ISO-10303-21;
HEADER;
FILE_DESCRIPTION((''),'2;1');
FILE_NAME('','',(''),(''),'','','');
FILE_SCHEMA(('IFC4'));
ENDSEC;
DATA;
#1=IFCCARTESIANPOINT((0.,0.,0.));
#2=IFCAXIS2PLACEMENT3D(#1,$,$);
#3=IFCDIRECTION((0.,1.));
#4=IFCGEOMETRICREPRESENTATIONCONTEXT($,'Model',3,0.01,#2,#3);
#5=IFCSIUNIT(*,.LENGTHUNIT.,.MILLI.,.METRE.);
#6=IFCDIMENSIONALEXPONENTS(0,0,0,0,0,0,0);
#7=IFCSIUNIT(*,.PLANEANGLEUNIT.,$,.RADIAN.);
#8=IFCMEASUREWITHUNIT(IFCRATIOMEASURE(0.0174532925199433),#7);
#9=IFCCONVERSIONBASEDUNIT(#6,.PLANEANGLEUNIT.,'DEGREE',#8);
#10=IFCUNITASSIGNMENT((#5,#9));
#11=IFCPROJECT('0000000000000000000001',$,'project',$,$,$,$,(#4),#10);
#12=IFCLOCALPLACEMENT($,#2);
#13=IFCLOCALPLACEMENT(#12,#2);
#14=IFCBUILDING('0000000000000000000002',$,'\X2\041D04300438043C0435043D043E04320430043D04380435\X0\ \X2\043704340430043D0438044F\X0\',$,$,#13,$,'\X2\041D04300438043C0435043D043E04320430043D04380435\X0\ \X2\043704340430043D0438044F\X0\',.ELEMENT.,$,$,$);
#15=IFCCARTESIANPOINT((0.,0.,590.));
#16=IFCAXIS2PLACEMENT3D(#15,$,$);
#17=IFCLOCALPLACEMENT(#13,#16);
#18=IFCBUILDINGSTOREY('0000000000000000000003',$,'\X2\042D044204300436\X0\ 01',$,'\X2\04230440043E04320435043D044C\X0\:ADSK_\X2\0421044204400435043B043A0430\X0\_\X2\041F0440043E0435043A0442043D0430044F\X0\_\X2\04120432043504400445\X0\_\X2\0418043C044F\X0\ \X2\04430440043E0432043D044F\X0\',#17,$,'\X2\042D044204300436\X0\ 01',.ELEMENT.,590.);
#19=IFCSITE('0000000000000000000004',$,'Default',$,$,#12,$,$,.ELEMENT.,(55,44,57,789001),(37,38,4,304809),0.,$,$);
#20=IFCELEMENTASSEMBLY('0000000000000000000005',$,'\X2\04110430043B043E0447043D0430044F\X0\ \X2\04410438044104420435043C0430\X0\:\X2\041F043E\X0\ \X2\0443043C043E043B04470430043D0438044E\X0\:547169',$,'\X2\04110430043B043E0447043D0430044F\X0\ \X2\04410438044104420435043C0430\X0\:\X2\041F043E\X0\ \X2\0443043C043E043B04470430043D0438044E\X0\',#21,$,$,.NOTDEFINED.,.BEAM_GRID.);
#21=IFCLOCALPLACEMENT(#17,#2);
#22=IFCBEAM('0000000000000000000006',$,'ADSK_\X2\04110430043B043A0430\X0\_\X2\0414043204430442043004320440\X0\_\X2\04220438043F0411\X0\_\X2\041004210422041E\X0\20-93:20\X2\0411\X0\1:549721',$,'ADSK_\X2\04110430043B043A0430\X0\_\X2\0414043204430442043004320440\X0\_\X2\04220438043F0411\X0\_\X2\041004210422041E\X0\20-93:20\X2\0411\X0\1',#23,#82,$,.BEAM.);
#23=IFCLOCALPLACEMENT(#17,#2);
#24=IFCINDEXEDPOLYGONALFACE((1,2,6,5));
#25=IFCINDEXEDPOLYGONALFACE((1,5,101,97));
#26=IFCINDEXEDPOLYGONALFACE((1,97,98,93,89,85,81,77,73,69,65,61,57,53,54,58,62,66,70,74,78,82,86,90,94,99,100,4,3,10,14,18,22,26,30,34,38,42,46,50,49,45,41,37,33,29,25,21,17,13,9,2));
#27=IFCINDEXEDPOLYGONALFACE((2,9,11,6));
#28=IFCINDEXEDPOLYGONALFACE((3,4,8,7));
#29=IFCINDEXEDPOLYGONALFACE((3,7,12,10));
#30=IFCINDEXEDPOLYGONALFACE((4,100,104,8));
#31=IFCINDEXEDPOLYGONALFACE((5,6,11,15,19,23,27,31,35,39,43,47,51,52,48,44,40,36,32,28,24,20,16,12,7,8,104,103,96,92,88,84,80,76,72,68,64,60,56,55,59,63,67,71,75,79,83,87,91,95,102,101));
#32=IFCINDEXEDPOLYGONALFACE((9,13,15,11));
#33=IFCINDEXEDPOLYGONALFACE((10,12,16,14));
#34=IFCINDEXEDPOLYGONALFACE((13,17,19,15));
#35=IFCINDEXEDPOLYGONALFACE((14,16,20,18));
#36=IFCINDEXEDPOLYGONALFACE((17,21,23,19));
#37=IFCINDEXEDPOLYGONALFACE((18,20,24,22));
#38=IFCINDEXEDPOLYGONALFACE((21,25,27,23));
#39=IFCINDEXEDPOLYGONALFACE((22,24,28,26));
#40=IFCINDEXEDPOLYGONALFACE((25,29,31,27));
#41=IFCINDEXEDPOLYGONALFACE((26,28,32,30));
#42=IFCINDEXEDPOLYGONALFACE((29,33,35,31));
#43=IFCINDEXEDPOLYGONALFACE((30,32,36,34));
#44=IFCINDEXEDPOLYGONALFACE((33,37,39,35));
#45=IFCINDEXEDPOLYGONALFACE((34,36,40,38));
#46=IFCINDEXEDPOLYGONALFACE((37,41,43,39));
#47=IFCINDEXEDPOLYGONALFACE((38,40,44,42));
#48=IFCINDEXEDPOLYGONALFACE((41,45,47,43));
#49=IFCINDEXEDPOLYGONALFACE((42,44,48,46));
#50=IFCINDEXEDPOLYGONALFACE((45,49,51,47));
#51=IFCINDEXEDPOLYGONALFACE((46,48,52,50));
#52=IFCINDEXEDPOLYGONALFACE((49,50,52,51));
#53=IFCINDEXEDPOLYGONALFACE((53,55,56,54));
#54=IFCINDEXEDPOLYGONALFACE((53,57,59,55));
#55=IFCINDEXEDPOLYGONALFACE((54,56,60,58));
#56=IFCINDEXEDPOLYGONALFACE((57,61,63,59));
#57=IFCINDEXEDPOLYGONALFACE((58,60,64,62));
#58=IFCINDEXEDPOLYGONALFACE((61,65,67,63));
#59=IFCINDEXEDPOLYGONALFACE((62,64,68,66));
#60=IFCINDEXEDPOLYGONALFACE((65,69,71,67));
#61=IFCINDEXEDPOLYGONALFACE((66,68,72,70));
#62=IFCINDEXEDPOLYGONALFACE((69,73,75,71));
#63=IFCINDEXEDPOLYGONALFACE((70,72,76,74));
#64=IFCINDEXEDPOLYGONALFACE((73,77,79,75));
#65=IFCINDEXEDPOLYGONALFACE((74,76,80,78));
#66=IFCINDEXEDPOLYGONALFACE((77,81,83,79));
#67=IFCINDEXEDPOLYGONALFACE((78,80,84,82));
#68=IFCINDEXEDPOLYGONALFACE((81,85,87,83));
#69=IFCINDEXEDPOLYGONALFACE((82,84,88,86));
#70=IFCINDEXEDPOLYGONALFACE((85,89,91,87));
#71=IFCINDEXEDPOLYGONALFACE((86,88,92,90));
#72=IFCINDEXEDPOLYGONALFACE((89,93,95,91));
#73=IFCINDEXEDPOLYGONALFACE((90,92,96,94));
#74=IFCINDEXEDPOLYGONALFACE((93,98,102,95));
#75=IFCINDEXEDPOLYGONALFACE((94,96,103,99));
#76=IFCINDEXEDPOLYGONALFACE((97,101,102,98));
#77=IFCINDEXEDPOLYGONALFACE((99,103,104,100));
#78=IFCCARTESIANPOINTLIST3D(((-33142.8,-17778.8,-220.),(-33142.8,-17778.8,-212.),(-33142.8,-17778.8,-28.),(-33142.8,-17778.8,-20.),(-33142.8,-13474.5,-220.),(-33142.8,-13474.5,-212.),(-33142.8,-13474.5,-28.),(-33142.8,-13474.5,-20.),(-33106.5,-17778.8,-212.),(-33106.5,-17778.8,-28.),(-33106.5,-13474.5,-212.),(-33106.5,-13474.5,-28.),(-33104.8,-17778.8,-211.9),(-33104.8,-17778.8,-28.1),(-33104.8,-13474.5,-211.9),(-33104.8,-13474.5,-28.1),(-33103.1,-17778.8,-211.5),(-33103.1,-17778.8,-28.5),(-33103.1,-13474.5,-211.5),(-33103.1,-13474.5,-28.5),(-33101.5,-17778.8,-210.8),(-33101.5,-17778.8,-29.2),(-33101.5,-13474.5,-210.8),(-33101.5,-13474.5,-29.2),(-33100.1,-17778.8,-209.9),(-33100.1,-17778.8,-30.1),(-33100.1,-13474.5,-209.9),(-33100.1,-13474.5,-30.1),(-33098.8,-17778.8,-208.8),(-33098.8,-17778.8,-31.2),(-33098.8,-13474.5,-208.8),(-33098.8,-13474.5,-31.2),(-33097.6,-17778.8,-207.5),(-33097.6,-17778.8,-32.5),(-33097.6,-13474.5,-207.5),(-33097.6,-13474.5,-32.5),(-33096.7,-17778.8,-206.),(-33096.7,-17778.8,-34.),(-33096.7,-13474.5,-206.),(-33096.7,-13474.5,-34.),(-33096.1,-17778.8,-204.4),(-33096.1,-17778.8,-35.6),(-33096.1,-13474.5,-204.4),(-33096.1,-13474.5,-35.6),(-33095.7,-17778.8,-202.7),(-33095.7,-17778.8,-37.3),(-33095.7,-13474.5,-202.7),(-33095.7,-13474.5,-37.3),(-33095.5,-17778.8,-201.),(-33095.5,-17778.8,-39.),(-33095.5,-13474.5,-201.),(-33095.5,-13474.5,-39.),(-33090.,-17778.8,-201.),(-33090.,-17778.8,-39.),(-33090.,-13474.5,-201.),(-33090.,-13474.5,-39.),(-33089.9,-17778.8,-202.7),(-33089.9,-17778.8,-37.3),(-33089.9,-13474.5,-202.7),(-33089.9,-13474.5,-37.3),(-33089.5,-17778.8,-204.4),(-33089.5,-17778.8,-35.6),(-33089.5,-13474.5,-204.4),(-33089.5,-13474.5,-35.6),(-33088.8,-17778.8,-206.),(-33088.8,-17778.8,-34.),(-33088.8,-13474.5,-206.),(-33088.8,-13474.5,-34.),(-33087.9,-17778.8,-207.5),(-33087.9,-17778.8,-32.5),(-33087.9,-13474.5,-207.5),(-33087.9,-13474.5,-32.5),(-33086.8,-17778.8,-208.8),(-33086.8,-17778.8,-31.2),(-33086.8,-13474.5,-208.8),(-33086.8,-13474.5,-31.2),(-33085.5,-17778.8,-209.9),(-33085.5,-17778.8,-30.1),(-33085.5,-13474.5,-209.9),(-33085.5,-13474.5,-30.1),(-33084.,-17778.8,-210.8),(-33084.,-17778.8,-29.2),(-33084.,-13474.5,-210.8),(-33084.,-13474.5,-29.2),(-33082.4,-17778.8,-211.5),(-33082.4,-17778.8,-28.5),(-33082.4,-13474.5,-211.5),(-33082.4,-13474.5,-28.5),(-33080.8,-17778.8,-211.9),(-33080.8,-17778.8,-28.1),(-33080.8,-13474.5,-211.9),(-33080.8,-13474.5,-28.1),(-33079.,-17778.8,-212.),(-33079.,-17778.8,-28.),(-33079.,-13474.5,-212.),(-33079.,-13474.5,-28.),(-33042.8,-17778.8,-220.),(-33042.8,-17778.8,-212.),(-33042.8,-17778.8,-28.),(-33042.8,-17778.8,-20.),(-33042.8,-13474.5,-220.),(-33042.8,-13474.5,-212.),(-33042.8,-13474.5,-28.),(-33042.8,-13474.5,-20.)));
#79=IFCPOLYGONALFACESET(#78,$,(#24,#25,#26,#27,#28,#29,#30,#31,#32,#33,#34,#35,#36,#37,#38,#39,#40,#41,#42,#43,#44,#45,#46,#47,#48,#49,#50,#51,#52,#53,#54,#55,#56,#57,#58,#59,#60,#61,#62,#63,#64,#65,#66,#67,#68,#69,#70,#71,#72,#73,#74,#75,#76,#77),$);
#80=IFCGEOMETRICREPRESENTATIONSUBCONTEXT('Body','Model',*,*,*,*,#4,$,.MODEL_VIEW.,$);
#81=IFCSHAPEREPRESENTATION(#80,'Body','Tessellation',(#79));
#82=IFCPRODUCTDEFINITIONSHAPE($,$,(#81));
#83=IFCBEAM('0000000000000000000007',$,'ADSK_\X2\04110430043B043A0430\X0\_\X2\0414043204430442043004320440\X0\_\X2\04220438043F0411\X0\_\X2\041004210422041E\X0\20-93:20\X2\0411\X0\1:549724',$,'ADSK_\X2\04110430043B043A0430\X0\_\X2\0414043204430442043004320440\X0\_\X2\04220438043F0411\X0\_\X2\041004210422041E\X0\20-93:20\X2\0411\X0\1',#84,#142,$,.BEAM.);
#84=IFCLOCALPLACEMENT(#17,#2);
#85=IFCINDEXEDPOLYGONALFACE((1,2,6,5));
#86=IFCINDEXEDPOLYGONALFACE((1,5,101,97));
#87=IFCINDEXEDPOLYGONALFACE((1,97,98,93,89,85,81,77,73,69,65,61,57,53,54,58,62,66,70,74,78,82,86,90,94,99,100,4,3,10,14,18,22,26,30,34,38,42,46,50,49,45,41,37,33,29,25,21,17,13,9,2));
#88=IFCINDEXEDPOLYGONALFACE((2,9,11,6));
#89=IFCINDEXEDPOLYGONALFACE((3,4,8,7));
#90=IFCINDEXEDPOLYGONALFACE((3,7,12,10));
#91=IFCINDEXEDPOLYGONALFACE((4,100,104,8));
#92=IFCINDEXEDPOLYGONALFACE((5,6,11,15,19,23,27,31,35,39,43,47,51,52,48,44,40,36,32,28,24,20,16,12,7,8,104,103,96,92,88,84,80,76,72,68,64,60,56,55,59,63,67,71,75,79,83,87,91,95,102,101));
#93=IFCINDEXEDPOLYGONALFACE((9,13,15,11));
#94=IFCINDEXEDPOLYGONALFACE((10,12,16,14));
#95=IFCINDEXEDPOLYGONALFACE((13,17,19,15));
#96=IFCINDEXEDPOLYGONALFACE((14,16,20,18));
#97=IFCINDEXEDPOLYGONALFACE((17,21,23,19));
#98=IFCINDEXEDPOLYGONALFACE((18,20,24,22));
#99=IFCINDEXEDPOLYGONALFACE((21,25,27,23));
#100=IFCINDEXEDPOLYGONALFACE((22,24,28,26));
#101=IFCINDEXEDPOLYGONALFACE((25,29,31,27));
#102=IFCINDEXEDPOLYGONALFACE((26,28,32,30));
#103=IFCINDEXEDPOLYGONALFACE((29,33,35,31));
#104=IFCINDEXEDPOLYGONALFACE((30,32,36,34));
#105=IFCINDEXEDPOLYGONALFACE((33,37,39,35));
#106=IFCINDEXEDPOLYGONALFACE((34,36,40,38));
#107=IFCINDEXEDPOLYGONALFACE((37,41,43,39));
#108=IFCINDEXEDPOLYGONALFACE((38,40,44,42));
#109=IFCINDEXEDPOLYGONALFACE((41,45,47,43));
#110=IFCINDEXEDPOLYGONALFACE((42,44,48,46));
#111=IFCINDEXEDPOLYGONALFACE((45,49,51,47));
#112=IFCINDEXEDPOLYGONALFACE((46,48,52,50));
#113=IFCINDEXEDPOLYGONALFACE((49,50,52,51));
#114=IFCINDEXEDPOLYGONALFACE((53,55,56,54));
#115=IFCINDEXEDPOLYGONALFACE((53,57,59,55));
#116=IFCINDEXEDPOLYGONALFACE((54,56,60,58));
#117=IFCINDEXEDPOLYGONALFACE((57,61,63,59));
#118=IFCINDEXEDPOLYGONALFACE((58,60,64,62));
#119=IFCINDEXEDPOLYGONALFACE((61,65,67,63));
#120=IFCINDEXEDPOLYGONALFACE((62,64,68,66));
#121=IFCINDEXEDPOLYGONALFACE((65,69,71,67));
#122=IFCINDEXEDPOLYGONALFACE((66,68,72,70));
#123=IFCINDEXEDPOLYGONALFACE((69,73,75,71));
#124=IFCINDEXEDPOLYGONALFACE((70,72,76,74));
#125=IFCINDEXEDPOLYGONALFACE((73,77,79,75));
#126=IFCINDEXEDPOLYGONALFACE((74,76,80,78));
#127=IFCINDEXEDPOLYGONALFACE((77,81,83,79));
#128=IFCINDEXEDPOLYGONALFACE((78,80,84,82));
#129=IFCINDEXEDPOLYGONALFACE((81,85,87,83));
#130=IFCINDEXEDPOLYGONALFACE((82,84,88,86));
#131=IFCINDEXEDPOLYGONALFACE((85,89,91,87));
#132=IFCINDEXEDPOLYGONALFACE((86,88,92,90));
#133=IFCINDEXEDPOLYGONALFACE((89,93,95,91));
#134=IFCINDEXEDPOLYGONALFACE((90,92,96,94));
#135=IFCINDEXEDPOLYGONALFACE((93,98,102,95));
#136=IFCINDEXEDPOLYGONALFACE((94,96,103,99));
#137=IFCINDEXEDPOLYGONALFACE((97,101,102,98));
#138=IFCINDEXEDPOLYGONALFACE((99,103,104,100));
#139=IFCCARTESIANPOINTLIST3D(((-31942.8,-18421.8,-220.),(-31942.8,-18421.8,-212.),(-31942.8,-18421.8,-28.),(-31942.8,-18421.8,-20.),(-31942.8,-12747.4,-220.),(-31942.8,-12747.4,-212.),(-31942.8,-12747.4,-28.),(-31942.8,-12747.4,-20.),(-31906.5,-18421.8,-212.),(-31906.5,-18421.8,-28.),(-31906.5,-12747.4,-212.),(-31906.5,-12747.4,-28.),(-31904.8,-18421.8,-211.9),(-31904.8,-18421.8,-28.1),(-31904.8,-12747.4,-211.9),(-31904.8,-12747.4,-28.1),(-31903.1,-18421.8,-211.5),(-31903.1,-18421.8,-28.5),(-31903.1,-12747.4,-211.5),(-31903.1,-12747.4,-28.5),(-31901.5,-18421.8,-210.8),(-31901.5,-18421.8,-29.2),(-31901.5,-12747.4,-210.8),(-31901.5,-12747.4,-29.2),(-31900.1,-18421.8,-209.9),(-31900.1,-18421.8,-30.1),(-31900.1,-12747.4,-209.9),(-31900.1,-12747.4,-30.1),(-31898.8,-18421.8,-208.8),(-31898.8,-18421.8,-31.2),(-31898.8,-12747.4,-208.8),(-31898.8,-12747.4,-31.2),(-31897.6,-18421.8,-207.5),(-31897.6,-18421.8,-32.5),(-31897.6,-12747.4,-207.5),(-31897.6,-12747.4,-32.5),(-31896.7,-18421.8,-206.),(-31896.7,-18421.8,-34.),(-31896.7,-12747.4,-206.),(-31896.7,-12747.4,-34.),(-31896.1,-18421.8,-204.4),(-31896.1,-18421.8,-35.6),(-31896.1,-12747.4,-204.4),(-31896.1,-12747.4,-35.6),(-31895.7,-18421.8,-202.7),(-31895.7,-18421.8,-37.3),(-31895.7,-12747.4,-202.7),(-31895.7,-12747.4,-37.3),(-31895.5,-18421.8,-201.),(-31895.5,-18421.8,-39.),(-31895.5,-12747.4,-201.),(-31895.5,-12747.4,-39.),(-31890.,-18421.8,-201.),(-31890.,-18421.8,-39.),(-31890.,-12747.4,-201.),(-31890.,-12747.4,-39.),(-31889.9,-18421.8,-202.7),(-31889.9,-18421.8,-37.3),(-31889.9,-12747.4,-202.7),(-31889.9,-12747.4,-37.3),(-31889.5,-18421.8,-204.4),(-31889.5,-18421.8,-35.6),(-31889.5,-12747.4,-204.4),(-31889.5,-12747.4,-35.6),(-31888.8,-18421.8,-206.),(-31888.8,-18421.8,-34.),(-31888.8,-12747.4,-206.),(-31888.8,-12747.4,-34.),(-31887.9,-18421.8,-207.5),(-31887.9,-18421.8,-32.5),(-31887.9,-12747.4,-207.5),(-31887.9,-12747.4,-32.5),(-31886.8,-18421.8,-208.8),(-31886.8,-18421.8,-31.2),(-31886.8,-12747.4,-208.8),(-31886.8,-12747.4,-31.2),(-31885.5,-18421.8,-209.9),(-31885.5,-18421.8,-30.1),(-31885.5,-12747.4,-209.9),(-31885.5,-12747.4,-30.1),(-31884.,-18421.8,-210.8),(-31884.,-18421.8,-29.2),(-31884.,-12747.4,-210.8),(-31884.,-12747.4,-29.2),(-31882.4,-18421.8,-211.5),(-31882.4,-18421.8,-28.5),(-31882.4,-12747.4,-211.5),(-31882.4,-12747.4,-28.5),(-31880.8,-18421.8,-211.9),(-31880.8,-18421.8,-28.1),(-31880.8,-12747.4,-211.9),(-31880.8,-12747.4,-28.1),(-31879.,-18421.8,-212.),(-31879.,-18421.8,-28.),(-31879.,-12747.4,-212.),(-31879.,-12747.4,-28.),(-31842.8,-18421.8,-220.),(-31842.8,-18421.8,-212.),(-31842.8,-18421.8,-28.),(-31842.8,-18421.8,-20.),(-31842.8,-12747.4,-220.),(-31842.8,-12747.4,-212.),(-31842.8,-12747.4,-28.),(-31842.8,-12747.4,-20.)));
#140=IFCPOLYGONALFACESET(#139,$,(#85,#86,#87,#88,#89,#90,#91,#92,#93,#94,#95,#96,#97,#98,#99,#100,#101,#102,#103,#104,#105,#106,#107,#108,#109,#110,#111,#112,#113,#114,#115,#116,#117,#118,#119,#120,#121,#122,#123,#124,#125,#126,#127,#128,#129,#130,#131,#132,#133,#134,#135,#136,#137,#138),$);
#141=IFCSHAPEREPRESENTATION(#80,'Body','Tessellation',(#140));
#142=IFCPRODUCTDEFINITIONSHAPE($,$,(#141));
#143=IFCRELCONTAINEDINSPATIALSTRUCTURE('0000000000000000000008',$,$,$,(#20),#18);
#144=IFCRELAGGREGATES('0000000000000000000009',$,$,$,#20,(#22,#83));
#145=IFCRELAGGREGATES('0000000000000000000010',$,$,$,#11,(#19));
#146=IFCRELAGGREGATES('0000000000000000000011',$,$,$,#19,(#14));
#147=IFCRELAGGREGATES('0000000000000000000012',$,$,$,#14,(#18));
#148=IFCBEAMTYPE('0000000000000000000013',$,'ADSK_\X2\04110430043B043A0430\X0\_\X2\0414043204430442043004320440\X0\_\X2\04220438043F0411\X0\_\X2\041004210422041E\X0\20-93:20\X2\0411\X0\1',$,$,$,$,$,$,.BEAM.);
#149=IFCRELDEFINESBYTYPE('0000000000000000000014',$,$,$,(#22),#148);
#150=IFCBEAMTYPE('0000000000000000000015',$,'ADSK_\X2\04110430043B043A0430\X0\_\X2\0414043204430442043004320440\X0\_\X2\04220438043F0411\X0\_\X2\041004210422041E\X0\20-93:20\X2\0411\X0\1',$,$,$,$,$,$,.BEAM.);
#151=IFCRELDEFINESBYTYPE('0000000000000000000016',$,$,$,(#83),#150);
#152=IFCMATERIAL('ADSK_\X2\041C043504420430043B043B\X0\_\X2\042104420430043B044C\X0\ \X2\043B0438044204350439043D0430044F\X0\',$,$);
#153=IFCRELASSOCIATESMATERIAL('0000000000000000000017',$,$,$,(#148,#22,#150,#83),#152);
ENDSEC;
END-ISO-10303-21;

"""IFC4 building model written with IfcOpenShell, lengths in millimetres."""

from ifc_helpers import new_model, entity, si_unit, converted_unit, direction, frame, origin, place, context, subcontext, project, spatial, indexed_curve, outline, extrude, source, transform, mapped, material, type_object, type_shapes, element, aggregate, save


model = new_model("IFC4")

# Units and contexts
model_context = context("Model", 3, precision=0.01, world=origin(), true_north=direction((0.0, 1.0)))
body_context = subcontext(model_context, "Body", "Model", "MODEL_VIEW")
ifc_project = project(units=[si_unit("LENGTHUNIT", "METRE", prefix="MILLI"), converted_unit("PLANEANGLEUNIT", "DEGREE", entity("IfcRatioMeasure", 0.0174532925199433), si_unit("PLANEANGLEUNIT", "RADIAN"), dimensions=[0, 0, 0, 0, 0, 0, 0])], contexts=[model_context])

# Site, building, storey
site_placement = place(None, origin())
site = spatial("IfcSite", under=ifc_project, at=site_placement, Name="Default", CompositionType="ELEMENT", RefLatitude=(55, 44, 57, 789001), RefLongitude=(37, 38, 4, 304809), RefElevation=0.0)
building_placement = place(site_placement, origin())
building = spatial("IfcBuilding", under=site, at=building_placement, Name="Наименование здания", LongName="Наименование здания", CompositionType="ELEMENT")
storey_placement = place(building_placement, frame((0.0, 0.0, 590.0)))
storey = spatial("IfcBuildingStorey", under=building, at=storey_placement, Name="Этаж 01", ObjectType="Уровень:ADSK_Стрелка_Проектная_Вверх_Имя уровня", LongName="Этаж 01", CompositionType="ELEMENT", Elevation=590.0)

# Element assembly, beams
assembly_placement = place(storey_placement, origin())
assembly = element("IfcElementAssembly", 1, at=assembly_placement, inside=storey, Name="Балочная система:По умолчанию:547169", ObjectType="Балочная система:По умолчанию", AssemblyPlace="NOTDEFINED", PredefinedType="BEAM_GRID")
ifc_material_1 = material(Name="ADSK_Металл_Сталь литейная")
beam_type_1 = type_object("IfcBeamType", Name="ADSK_Балка_Двутавр_ТипБ_АСТО20-93:20Б1", PredefinedType="BEAM", material=ifc_material_1)
shared_shape_1 = source(origin(), body_context, "Body", "SweptSolid", [
    extrude(outline(indexed_curve([(-100.0, -50.0), (-92.0, -50.0), (-92.0, -13.8), (-91.9, -12.0), (-91.5, -10.4), (-90.8, -8.8), (-89.9, -7.3), (-88.8, -6.0), (-87.5, -4.9), (-86.0, -3.9), (-84.4, -3.3), (-82.7, -2.9), (-81.0, -2.8), (81.0, -2.8), (82.7, -2.9), (84.4, -3.3), (86.0, -3.9), (87.5, -4.9), (88.8, -6.0), (89.9, -7.3), (90.8, -8.8), (91.5, -10.4), (91.9, -12.0), (92.0, -13.7), (92.0, -50.0), (100.0, -50.0), (100.0, 50.0), (92.0, 50.0), (92.0, 13.8), (91.9, 12.0), (91.5, 10.4), (90.8, 8.8), (89.9, 7.3), (88.8, 6.0), (87.5, 4.9), (86.0, 3.9), (84.4, 3.3), (82.7, 2.9), (81.0, 2.8), (-81.0, 2.8), (-82.7, 2.9), (-84.4, 3.3), (-86.0, 3.9), (-87.5, 4.9), (-88.8, 6.0), (-89.9, 7.3), (-90.8, 8.8), (-91.5, 10.4), (-91.9, 12.0), (-92.0, 13.8), (-92.0, 50.0), (-100.0, 50.0), (-100.0, -50.0)], self_intersect=False)), frame((-2152.1, 0.0, -100.0), z_axis=(1.0, 0.0, 0.0), x_axis=(0.0, 0.0, -1.0)), (0.0, 0.0, 1.0), 4304.2),
])
type_shapes(beam_type_1, [shared_shape_1])
beam_1_placement = place(assembly_placement, frame((-33092.8, -15626.6, -20.0), z_axis=(0.0, 0.0, 1.0), x_axis=(0.0, 1.0, 0.0)))
beam_1 = element("IfcBeam", 2, at=beam_1_placement, type_object=beam_type_1, material=ifc_material_1, Name="ADSK_Балка_Двутавр_ТипБ_АСТО20-93:20Б1:549721", ObjectType="ADSK_Балка_Двутавр_ТипБ_АСТО20-93:20Б1", PredefinedType="BEAM", context=body_context, shape_type="MappedRepresentation", body=[
    mapped(shared_shape_1, transform((0.0, 0.0, 0.0), scale=1.0)),
])
beam_type_2 = type_object("IfcBeamType", Name="ADSK_Балка_Двутавр_ТипБ_АСТО20-93:20Б1", PredefinedType="BEAM", material=ifc_material_1)
shared_shape_2 = source(origin(), body_context, "Body", "SweptSolid", [
    extrude(outline(indexed_curve([(-100.0, -50.0), (-92.0, -50.0), (-92.0, -13.8), (-91.9, -12.0), (-91.5, -10.4), (-90.8, -8.8), (-89.9, -7.3), (-88.8, -6.0), (-87.5, -4.9), (-86.0, -3.9), (-84.4, -3.3), (-82.7, -2.9), (-81.0, -2.8), (81.0, -2.8), (82.7, -2.9), (84.4, -3.3), (86.0, -3.9), (87.5, -4.9), (88.8, -6.0), (89.9, -7.3), (90.8, -8.8), (91.5, -10.4), (91.9, -12.0), (92.0, -13.7), (92.0, -50.0), (100.0, -50.0), (100.0, 50.0), (92.0, 50.0), (92.0, 13.8), (91.9, 12.0), (91.5, 10.4), (90.8, 8.8), (89.9, 7.3), (88.8, 6.0), (87.5, 4.9), (86.0, 3.9), (84.4, 3.3), (82.7, 2.9), (81.0, 2.8), (-81.0, 2.8), (-82.7, 2.9), (-84.4, 3.3), (-86.0, 3.9), (-87.5, 4.9), (-88.8, 6.0), (-89.9, 7.3), (-90.8, 8.8), (-91.5, 10.4), (-91.9, 12.0), (-92.0, 13.8), (-92.0, 50.0), (-100.0, 50.0), (-100.0, -50.0)], self_intersect=False)), frame((-2837.2, 0.0, -100.0), z_axis=(1.0, 0.0, 0.0), x_axis=(0.0, 0.0, -1.0)), (0.0, 0.0, 1.0), 5674.4),
])
type_shapes(beam_type_2, [shared_shape_2])
beam_2_placement = place(assembly_placement, frame((-31892.8, -15584.6, -20.0), z_axis=(0.0, 0.0, 1.0), x_axis=(0.0, 1.0, 0.0)))
beam_2 = element("IfcBeam", 3, at=beam_2_placement, type_object=beam_type_2, material=ifc_material_1, Name="ADSK_Балка_Двутавр_ТипБ_АСТО20-93:20Б1:549724", ObjectType="ADSK_Балка_Двутавр_ТипБ_АСТО20-93:20Б1", PredefinedType="BEAM", context=body_context, shape_type="MappedRepresentation", body=[
    mapped(shared_shape_2, transform((0.0, 0.0, 0.0), scale=1.0)),
])
aggregate(assembly, [beam_1, beam_2])

save(model, "model.ifc")
